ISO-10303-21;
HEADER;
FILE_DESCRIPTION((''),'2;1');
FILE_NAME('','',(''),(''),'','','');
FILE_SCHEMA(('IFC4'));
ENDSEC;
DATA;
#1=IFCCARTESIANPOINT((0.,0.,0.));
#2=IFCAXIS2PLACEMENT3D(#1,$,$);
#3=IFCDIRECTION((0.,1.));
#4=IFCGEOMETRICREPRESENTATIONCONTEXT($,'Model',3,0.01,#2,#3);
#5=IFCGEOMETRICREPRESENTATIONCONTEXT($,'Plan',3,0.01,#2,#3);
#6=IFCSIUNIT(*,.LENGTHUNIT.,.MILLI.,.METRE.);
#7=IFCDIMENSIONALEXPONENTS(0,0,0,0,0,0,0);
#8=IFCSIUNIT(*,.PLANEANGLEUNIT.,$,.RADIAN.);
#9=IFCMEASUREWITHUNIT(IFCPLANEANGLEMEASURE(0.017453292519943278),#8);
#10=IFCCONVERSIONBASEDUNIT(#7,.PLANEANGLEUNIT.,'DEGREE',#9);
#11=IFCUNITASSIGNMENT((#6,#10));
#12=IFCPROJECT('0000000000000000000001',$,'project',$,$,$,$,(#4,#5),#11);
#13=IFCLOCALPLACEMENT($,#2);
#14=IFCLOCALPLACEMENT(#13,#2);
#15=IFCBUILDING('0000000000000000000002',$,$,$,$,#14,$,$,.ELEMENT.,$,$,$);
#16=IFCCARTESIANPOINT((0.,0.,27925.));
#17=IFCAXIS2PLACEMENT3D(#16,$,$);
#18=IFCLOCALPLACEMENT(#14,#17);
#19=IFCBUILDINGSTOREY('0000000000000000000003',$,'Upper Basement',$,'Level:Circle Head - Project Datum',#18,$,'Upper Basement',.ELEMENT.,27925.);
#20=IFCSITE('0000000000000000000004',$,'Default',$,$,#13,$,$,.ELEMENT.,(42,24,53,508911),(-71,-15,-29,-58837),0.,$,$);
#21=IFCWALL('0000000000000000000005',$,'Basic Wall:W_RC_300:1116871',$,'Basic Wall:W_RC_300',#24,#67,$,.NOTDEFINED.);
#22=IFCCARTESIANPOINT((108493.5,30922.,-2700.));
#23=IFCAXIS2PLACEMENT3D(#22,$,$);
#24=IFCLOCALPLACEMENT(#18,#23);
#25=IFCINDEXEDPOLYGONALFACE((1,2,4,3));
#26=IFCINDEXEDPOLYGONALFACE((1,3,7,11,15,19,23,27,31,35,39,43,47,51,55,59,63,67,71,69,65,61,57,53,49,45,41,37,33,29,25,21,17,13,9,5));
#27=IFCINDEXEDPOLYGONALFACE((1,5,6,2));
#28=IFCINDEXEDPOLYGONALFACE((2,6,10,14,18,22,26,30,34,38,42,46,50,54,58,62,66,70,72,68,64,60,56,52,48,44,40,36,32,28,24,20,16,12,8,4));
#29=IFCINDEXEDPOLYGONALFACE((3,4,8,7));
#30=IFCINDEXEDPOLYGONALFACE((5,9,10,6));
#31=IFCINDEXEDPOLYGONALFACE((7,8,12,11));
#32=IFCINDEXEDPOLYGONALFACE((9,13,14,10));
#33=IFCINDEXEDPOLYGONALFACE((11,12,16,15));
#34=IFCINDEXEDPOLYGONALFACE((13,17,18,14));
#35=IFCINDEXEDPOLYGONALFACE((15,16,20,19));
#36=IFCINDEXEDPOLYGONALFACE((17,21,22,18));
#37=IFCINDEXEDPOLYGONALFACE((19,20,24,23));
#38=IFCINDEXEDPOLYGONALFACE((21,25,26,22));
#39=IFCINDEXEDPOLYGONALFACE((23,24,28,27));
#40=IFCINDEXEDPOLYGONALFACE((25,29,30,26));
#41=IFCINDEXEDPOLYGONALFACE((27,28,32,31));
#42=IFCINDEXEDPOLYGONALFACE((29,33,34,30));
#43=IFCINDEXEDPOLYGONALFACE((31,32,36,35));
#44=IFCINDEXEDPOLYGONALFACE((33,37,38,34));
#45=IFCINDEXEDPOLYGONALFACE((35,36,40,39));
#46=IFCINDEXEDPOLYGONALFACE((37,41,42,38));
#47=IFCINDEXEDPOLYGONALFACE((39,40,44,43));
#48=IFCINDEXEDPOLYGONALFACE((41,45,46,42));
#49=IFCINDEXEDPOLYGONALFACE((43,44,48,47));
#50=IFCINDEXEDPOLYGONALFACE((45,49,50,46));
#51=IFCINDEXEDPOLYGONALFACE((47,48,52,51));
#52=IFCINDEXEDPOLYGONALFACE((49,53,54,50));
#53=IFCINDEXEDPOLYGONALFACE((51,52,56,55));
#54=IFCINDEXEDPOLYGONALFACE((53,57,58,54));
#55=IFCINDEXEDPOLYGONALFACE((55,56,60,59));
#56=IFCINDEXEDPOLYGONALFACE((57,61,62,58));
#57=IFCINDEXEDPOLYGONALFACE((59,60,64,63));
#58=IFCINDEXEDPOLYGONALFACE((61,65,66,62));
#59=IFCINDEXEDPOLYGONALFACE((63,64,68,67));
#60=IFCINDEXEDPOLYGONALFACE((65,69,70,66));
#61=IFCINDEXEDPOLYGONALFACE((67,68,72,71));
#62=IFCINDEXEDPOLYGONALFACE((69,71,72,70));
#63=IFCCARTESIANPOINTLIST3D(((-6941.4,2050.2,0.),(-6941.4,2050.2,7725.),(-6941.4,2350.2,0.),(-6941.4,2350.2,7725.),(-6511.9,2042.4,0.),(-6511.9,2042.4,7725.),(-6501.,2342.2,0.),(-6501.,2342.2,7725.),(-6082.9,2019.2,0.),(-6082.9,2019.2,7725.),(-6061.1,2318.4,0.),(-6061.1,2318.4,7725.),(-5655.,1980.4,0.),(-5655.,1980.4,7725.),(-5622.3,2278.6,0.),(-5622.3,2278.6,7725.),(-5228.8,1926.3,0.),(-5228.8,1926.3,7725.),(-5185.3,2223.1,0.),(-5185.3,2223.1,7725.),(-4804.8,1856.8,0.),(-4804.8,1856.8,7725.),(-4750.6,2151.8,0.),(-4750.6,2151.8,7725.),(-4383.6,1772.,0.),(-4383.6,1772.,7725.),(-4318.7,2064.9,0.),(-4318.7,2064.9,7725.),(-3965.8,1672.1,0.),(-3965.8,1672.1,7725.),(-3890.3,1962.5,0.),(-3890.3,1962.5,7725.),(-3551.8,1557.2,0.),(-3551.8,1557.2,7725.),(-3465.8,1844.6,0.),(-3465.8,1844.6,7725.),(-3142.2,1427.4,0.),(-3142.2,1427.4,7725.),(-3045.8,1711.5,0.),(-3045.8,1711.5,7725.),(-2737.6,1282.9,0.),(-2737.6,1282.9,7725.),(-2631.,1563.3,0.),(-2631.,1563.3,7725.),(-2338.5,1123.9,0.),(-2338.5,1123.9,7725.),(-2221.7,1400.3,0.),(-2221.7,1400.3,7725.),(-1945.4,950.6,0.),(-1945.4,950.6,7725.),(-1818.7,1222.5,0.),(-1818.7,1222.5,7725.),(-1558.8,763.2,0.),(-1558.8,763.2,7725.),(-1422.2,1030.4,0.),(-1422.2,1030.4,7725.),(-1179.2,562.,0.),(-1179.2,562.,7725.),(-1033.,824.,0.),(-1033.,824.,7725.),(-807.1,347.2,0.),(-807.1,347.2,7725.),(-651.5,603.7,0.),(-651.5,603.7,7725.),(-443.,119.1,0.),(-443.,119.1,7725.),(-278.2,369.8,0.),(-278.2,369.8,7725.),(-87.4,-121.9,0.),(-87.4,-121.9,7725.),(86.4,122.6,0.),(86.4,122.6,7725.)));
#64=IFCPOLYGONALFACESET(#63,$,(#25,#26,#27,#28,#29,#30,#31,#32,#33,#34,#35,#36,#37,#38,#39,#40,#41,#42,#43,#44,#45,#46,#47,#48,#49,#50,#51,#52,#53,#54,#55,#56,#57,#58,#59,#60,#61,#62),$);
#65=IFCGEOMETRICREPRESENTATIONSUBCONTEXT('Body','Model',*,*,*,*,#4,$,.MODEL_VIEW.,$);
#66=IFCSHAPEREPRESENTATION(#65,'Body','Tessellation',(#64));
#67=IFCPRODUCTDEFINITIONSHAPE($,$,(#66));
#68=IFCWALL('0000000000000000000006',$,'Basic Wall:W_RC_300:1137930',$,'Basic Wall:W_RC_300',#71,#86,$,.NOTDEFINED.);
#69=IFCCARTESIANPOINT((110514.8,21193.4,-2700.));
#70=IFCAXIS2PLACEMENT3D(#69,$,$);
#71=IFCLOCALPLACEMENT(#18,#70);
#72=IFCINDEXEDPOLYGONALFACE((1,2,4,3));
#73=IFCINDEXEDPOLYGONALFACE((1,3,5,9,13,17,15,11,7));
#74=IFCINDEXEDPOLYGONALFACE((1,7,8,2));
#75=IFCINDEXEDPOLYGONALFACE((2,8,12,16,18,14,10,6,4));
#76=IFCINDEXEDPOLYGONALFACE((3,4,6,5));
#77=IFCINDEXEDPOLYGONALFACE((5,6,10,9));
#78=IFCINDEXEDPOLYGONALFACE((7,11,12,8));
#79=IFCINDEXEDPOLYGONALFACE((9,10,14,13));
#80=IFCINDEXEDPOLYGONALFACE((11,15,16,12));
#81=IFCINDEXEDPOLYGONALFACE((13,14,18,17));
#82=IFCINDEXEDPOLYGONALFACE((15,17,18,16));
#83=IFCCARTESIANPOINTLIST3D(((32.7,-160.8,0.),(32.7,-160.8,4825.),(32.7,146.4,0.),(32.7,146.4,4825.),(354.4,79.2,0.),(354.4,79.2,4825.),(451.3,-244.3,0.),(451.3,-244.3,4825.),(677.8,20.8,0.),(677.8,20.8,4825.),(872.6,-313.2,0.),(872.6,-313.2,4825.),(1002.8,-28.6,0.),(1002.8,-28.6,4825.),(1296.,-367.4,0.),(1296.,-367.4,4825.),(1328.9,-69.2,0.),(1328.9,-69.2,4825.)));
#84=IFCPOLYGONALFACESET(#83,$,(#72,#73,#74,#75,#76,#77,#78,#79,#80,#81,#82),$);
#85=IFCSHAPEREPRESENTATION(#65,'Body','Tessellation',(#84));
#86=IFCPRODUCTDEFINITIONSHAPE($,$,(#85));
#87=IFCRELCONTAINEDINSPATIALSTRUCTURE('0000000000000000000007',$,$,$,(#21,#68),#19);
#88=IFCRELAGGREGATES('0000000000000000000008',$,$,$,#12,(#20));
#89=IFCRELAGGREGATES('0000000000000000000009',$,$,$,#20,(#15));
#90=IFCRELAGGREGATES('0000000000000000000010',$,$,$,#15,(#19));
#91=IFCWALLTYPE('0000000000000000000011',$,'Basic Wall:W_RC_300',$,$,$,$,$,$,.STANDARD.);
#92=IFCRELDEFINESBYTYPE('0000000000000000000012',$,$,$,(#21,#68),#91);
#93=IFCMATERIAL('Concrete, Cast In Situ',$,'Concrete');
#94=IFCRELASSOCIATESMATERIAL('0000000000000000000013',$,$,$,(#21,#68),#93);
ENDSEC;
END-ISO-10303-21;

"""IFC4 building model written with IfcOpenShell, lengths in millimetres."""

from ifc_helpers import new_model, entity, si_unit, converted_unit, direction, frame, origin, place, context, subcontext, project, spatial, line, arc, indexed_curve, outline, extrude, material, type_object, element, save


model = new_model("IFC4")

# Units and contexts
model_context = context("Model", 3, precision=0.01, world=origin(), true_north=direction((0.0, 1.0)))
plan_context = context("Plan", 3, precision=0.01, world=origin(), true_north=direction((0.0, 1.0)))
body_context = subcontext(model_context, "Body", "Model", "MODEL_VIEW")
ifc_project = project(units=[si_unit("LENGTHUNIT", "METRE", prefix="MILLI"), converted_unit("PLANEANGLEUNIT", "DEGREE", entity("IfcPlaneAngleMeasure", 0.017453292519943278), si_unit("PLANEANGLEUNIT", "RADIAN"), dimensions=[0, 0, 0, 0, 0, 0, 0])], contexts=[model_context, plan_context])

# Site, building, storey
site_placement = place(None, origin())
site = spatial("IfcSite", under=ifc_project, at=site_placement, Name="Default", CompositionType="ELEMENT", RefLatitude=(42, 24, 53, 508911), RefLongitude=(-71, -15, -29, -58837), RefElevation=0.0)
building_placement = place(site_placement, origin())
building = spatial("IfcBuilding", under=site, at=building_placement, CompositionType="ELEMENT")
storey_placement = place(building_placement, frame((0.0, 0.0, 27925.0)))
storey = spatial("IfcBuildingStorey", under=building, at=storey_placement, Name="Upper Basement", ObjectType="Level:Circle Head - Project Datum", LongName="Upper Basement", CompositionType="ELEMENT", Elevation=27925.0)

# Walls
ifc_material_1 = material(Name="Concrete, Cast In Situ", Category="Concrete")
wall_type = type_object("IfcWallType", Name="Basic Wall:W_RC_300", PredefinedType="STANDARD")
wall_1_placement = place(storey_placement, frame((108493.5, 30922.0, -2700.0)))
element("IfcWall", 1, at=wall_1_placement, inside=storey, type_object=wall_type, material=ifc_material_1, Name="Basic Wall:W_RC_300:1116871", ObjectType="Basic Wall:W_RC_300", PredefinedType="NOTDEFINED", context=body_context, shape_type="SweptSolid", body=[
    extrude(outline(indexed_curve([(-6941.4, 2050.2), (-3346.4, 1494.2), (-87.4, -121.9), (86.4, 122.6), (-3255.2, 1780.0), (-6941.4, 2350.2)], segments=[arc(1, 2, 3), line(3, 4), arc(4, 5, 6), line(6, 1)], self_intersect=False)), origin(), (0.0, 0.0, 1.0), 7725.0),
])
wall_2_placement = place(storey_placement, frame((110514.8, 21193.4, -2700.0)))
element("IfcWall", 2, at=wall_2_placement, inside=storey, type_object=wall_type, material=ifc_material_1, Name="Basic Wall:W_RC_300:1137930", ObjectType="Basic Wall:W_RC_300", PredefinedType="NOTDEFINED", context=body_context, shape_type="SweptSolid", body=[
    extrude(outline(indexed_curve([(1328.9, -69.2), (677.8, 20.8), (32.7, 146.4), (32.7, -160.8), (661.6, -280.5), (1296.0, -367.4)], segments=[arc(1, 2, 3), line(3, 4), arc(4, 5, 6), line(6, 1)], self_intersect=False)), origin(), (0.0, 0.0, 1.0), 4825.0),
])

save(model, "model.ifc")
